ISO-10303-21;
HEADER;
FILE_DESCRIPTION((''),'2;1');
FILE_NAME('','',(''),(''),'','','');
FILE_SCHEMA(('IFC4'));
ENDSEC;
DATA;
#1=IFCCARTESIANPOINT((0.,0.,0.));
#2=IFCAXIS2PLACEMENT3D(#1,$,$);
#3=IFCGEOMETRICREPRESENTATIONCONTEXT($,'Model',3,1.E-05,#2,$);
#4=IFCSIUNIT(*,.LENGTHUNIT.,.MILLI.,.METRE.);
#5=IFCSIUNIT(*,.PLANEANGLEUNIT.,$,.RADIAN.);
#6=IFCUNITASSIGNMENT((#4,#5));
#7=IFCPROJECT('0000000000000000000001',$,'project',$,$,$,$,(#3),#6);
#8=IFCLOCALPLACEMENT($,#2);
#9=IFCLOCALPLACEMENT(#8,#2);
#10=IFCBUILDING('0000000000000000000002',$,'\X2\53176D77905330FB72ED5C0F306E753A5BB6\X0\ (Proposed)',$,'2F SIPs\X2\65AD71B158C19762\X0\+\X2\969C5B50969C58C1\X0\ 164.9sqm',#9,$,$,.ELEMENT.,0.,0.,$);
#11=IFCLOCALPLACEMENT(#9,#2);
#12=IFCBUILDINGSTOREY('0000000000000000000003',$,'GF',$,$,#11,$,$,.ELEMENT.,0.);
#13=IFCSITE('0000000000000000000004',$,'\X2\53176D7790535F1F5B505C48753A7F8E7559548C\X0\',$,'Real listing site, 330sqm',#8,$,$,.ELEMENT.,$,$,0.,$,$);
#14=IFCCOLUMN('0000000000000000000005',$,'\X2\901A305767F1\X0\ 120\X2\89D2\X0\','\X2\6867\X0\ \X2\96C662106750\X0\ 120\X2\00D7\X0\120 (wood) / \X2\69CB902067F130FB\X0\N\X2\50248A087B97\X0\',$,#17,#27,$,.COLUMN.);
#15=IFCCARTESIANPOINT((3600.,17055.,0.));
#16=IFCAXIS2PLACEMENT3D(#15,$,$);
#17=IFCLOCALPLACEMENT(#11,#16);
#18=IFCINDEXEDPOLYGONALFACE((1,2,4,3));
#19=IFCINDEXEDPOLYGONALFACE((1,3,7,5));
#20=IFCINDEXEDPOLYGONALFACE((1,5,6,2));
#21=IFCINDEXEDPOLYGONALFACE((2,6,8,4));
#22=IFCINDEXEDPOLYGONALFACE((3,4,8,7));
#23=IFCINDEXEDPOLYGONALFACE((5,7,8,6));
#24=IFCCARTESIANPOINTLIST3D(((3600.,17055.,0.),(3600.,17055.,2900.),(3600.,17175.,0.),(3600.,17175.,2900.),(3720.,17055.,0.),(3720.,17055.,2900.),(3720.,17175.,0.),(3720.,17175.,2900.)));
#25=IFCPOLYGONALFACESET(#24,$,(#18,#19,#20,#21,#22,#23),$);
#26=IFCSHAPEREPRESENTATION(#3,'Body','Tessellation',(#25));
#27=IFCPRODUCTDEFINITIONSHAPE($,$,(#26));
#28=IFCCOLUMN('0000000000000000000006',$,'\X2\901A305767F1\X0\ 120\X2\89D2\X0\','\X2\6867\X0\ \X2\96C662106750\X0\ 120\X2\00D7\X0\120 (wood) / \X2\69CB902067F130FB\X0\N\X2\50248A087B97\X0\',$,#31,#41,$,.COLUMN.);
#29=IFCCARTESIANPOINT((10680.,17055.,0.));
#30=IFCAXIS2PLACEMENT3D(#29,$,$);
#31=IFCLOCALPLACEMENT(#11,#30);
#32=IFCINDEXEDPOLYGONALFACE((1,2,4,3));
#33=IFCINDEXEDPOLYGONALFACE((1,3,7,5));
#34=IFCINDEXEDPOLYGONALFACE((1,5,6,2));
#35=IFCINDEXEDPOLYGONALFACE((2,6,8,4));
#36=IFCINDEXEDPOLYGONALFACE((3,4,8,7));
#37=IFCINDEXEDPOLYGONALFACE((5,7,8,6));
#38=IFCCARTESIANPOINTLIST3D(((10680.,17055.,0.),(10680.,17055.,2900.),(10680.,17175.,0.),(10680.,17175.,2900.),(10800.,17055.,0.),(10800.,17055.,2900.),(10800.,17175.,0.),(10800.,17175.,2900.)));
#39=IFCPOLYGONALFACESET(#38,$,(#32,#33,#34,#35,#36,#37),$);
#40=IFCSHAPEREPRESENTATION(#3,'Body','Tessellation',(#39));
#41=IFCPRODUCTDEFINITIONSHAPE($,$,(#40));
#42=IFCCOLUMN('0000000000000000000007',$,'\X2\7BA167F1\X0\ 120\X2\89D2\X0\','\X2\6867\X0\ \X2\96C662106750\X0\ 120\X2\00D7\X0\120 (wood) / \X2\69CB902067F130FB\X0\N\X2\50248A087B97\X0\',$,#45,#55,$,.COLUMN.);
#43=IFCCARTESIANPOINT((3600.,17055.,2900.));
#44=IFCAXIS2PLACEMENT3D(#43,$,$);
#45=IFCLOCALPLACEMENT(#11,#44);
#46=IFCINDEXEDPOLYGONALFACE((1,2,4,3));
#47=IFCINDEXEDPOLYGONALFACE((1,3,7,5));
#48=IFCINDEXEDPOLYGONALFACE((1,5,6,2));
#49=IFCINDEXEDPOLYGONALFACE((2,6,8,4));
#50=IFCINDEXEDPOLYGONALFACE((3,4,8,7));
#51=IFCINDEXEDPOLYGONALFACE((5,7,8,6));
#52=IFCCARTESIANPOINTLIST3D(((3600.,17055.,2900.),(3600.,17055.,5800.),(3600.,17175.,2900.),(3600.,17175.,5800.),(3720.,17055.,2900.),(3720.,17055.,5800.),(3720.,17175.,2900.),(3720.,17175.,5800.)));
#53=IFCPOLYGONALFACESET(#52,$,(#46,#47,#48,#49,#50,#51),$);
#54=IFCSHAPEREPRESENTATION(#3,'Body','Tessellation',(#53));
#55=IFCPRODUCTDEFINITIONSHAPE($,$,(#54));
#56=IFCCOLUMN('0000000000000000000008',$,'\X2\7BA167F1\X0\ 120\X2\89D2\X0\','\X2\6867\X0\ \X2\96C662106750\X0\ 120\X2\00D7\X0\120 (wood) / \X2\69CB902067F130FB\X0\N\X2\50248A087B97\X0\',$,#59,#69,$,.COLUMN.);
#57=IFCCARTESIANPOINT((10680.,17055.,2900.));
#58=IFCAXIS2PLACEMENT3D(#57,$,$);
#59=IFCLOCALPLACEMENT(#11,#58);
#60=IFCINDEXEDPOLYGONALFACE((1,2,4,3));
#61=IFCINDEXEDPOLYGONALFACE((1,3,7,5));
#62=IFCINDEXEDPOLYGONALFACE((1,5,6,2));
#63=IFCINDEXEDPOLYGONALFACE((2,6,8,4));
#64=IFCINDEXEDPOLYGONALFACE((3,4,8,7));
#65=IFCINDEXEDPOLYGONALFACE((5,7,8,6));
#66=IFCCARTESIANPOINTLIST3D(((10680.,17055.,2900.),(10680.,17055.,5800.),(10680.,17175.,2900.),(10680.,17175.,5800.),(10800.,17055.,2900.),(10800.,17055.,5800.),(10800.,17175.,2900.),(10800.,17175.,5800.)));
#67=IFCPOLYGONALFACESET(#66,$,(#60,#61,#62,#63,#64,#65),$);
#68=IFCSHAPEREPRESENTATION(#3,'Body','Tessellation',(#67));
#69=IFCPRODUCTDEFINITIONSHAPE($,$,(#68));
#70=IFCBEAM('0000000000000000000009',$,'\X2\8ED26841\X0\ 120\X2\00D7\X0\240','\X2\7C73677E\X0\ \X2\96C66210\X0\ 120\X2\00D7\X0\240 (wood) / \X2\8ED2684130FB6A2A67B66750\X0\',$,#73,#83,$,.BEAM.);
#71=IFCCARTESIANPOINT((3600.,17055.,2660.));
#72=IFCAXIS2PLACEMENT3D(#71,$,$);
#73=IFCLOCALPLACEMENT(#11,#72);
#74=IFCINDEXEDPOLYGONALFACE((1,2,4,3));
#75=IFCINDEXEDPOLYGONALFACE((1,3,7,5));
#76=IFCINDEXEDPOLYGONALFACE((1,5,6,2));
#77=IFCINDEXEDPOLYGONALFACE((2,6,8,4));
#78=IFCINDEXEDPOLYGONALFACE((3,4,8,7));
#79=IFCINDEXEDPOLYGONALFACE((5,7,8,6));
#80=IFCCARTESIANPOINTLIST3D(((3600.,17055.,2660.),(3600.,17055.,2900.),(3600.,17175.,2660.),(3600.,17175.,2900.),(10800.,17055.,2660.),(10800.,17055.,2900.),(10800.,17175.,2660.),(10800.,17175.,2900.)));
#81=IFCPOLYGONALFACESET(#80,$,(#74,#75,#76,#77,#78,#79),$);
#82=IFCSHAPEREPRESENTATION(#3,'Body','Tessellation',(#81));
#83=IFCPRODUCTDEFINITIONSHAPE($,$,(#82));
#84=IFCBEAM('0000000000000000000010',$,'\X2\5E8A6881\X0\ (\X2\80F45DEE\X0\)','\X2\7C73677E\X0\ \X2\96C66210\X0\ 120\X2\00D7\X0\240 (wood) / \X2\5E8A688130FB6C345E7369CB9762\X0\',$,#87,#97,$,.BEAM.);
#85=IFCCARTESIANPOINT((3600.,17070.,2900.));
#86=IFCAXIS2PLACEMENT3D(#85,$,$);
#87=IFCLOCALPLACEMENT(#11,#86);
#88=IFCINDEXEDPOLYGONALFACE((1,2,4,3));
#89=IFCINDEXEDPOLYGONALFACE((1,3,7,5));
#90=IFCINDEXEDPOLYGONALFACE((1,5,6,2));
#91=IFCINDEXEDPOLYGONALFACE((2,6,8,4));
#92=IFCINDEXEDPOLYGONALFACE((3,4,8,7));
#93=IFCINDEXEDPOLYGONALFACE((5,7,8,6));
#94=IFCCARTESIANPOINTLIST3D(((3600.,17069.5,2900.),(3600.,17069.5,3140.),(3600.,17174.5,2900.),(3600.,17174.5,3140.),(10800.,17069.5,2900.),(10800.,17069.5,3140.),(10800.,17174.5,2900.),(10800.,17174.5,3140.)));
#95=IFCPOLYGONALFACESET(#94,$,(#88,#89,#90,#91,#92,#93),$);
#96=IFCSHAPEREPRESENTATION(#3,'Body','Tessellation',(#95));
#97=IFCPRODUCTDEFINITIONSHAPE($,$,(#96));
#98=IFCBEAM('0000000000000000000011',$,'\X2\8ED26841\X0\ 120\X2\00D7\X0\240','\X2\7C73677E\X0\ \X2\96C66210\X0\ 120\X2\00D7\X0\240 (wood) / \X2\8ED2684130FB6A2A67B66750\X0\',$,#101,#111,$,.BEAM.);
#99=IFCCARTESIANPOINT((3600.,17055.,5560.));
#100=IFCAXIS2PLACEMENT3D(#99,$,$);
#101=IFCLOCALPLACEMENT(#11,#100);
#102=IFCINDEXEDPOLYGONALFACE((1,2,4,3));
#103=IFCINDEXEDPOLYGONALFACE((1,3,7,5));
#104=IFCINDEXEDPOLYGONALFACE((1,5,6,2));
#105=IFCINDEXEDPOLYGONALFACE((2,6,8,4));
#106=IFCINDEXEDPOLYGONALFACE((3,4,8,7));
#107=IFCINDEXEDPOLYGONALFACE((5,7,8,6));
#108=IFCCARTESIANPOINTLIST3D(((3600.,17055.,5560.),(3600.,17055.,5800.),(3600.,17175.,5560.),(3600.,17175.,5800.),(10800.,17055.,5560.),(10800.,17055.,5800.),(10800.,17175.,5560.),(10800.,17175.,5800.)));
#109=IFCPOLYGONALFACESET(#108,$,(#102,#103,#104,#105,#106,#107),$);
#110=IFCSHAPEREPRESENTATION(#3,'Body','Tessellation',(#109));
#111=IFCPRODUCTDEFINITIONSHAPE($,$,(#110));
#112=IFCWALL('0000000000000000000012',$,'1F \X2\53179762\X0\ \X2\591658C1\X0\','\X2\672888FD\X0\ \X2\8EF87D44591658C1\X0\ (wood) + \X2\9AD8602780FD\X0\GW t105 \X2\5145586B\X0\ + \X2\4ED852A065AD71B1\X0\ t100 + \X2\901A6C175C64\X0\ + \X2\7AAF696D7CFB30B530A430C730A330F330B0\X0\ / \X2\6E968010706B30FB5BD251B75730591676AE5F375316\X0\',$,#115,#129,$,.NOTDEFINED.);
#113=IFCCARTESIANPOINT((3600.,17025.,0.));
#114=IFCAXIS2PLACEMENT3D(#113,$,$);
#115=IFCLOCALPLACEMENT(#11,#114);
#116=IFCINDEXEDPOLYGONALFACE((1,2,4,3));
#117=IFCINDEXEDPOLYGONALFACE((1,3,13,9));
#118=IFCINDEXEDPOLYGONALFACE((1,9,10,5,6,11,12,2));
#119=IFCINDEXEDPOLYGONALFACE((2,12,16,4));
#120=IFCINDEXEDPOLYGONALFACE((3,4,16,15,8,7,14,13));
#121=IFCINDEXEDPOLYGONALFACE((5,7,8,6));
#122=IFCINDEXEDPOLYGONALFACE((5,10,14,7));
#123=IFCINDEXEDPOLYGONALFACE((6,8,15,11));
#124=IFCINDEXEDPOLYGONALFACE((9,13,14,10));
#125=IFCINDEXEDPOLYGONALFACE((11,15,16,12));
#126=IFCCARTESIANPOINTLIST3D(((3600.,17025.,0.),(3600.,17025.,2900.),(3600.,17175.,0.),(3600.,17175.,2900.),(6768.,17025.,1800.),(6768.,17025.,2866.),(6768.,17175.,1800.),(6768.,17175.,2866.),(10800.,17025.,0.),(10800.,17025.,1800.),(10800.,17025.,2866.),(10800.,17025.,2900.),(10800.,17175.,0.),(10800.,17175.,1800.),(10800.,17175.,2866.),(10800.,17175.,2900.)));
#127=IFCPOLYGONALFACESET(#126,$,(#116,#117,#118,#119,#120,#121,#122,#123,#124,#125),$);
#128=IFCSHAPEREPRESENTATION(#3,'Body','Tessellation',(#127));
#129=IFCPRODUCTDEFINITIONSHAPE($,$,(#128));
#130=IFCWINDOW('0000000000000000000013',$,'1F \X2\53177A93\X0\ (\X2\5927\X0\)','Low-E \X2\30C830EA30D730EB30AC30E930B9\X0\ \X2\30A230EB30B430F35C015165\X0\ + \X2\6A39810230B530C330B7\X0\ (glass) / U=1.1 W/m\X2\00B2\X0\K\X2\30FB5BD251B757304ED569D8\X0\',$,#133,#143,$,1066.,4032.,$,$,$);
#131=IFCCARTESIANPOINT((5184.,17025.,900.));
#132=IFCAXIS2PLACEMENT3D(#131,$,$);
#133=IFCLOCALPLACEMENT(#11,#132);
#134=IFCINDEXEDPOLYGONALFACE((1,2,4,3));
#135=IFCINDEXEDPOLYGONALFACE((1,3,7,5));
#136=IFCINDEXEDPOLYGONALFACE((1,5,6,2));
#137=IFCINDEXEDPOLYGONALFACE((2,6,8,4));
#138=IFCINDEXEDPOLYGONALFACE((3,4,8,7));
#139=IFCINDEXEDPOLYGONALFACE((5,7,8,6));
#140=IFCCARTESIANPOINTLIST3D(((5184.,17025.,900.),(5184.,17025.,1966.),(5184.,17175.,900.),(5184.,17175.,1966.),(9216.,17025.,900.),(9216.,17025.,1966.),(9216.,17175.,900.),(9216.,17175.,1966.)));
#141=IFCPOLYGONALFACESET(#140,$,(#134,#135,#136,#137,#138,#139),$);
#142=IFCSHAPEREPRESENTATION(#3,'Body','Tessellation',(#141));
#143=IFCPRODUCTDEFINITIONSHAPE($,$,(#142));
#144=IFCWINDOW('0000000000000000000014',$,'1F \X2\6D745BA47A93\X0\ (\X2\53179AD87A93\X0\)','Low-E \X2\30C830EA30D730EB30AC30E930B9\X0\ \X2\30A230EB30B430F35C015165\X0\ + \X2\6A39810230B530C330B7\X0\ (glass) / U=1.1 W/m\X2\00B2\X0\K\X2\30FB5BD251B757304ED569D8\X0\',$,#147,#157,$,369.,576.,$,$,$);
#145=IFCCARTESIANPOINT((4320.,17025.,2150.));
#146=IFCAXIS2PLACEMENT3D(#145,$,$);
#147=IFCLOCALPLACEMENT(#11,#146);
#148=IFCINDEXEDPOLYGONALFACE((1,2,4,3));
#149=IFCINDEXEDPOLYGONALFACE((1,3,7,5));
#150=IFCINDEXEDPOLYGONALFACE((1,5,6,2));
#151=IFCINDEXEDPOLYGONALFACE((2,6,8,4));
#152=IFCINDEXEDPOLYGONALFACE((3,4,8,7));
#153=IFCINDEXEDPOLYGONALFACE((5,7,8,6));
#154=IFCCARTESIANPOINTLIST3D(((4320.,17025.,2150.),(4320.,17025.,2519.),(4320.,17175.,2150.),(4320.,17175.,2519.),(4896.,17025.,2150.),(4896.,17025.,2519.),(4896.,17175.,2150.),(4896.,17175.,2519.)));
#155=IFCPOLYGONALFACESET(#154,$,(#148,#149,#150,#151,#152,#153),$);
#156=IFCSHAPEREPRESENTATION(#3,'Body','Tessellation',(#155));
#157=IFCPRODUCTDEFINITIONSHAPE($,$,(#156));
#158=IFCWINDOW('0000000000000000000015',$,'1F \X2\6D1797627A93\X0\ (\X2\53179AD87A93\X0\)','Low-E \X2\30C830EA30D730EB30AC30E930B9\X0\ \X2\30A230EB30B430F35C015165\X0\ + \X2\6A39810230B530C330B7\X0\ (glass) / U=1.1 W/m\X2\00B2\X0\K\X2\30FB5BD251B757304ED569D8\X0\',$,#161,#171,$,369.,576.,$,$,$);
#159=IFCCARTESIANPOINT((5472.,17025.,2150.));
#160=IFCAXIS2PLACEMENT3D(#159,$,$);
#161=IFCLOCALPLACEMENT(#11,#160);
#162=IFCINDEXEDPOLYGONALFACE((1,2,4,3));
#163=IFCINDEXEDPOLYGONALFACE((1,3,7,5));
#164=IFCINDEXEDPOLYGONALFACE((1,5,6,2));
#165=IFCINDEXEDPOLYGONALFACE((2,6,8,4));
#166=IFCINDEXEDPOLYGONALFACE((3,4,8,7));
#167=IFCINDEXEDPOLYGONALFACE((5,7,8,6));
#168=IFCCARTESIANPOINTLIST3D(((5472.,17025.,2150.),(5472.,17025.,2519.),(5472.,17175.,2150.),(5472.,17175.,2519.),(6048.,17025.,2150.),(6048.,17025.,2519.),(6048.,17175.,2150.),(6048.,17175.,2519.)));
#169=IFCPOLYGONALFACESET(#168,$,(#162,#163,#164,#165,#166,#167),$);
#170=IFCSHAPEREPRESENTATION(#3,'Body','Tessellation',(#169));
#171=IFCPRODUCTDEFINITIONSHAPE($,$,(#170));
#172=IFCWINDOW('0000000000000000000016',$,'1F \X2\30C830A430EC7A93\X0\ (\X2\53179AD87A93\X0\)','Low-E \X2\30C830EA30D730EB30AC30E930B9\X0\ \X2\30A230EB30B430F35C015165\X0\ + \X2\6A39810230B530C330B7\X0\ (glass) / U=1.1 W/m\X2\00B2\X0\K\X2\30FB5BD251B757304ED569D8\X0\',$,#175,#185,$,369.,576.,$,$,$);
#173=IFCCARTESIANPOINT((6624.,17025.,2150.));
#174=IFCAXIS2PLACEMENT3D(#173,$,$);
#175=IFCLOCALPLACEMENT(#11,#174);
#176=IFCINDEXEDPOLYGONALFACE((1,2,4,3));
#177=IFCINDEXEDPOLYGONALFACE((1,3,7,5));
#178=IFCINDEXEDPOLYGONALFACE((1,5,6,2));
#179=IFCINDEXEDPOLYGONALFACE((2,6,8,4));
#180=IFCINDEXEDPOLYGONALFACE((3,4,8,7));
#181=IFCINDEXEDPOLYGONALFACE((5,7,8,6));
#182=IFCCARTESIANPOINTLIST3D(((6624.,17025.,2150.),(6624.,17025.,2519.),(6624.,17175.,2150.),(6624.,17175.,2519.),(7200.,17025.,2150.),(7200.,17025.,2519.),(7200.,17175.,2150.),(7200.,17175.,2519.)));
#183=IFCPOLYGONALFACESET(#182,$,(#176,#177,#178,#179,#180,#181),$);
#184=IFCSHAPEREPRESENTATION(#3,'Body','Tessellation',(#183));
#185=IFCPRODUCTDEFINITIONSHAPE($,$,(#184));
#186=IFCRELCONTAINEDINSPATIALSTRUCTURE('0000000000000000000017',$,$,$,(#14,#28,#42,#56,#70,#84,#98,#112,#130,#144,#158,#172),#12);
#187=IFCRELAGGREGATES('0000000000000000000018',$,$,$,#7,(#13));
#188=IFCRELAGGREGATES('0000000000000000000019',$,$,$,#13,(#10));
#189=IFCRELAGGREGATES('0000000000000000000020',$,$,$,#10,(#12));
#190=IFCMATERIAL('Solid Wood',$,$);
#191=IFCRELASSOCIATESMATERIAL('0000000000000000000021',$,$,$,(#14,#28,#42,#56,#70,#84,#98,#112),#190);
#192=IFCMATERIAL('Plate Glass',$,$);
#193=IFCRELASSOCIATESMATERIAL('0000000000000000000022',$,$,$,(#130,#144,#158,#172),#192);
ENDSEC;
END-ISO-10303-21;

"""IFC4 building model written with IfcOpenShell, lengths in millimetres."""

from ifc_helpers import new_model, si_unit, frame, frame_2d, origin, place, context, project, spatial, rectangle, extrude, material, element, fill, save


model = new_model("IFC4")

# Units and contexts
model_context = context("Model", 3, precision=1e-05, world=origin())
ifc_project = project(units=[si_unit("LENGTHUNIT", "METRE", prefix="MILLI"), si_unit("PLANEANGLEUNIT", "RADIAN")], contexts=[model_context])

# Site, building, storey
site_placement = place(None, origin())
site = spatial("IfcSite", under=ifc_project, at=site_placement, Name="北海道弟子屈町美留和", ObjectType="Real listing site, 330sqm", CompositionType="ELEMENT", RefElevation=0.0)
building_placement = place(site_placement, origin())
building = spatial("IfcBuilding", under=site, at=building_placement, Name="北海道・狭小の町家 (Proposed)", ObjectType="2F SIPs断熱壁面+障子障壁 164.9sqm", CompositionType="ELEMENT", ElevationOfRefHeight=0.0, ElevationOfTerrain=0.0)
storey_placement = place(building_placement, origin())
storey = spatial("IfcBuildingStorey", under=building, at=storey_placement, Name="GF", CompositionType="ELEMENT", Elevation=0.0)

# Columns
ifc_material_1 = material(Name="Solid Wood")
column_1_placement = place(storey_placement, frame((3600.0, 17055.0, 0.0)))
element("IfcColumn", 1, at=column_1_placement, inside=storey, material=ifc_material_1, Name="通し柱 120角", Description="桧 集成材 120×120 (wood) / 構造柱・N値計算", PredefinedType="COLUMN", context=model_context, shape_type="SweptSolid", body=[
    extrude(rectangle(XDim=120.0, YDim=120.0, at=frame_2d((60.0, 60.0))), frame((3600.0, 17055.0, 0.0)), (0.0, 0.0, 1.0), 2900.0),
])
column_2_placement = place(storey_placement, frame((10680.0, 17055.0, 0.0)))
element("IfcColumn", 2, at=column_2_placement, inside=storey, material=ifc_material_1, Name="通し柱 120角", Description="桧 集成材 120×120 (wood) / 構造柱・N値計算", PredefinedType="COLUMN", context=model_context, shape_type="SweptSolid", body=[
    extrude(rectangle(XDim=120.0, YDim=120.0, at=frame_2d((60.0, 60.0))), frame((10680.0, 17055.0, 0.0)), (0.0, 0.0, 1.0), 2900.0),
])
column_3_placement = place(storey_placement, frame((3600.0, 17055.0, 2900.0)))
element("IfcColumn", 3, at=column_3_placement, inside=storey, material=ifc_material_1, Name="管柱 120角", Description="桧 集成材 120×120 (wood) / 構造柱・N値計算", PredefinedType="COLUMN", context=model_context, shape_type="SweptSolid", body=[
    extrude(rectangle(XDim=120.0, YDim=120.0, at=frame_2d((60.0, 60.0))), frame((3600.0, 17055.0, 2900.0)), (0.0, 0.0, 1.0), 2900.0),
])
column_4_placement = place(storey_placement, frame((10680.0, 17055.0, 2900.0)))
element("IfcColumn", 4, at=column_4_placement, inside=storey, material=ifc_material_1, Name="管柱 120角", Description="桧 集成材 120×120 (wood) / 構造柱・N値計算", PredefinedType="COLUMN", context=model_context, shape_type="SweptSolid", body=[
    extrude(rectangle(XDim=120.0, YDim=120.0, at=frame_2d((60.0, 60.0))), frame((10680.0, 17055.0, 2900.0)), (0.0, 0.0, 1.0), 2900.0),
])

# Beams
beam_1_placement = place(storey_placement, frame((3600.0, 17055.0, 2660.0)))
element("IfcBeam", 5, at=beam_1_placement, inside=storey, material=ifc_material_1, Name="軒桁 120×240", Description="米松 集成 120×240 (wood) / 軒桁・横架材", PredefinedType="BEAM", context=model_context, shape_type="SweptSolid", body=[
    extrude(rectangle(XDim=7200.0, YDim=120.0, at=frame_2d((3600.0, 60.0))), frame((3600.0, 17055.0, 2660.0)), (0.0, 0.0, 1.0), 240.0),
])
beam_2_placement = place(storey_placement, frame((3600.0, 17070.0, 2900.0)))
element("IfcBeam", 6, at=beam_2_placement, inside=storey, material=ifc_material_1, Name="床梁 (胴差)", Description="米松 集成 120×240 (wood) / 床梁・水平構面", PredefinedType="BEAM", context=model_context, shape_type="SweptSolid", body=[
    extrude(rectangle(XDim=7200.0, YDim=105.0, at=frame_2d((3600.0, 52.0))), frame((3600.0, 17070.0, 2900.0)), (0.0, 0.0, 1.0), 240.0),
])
beam_3_placement = place(storey_placement, frame((3600.0, 17055.0, 5560.0)))
element("IfcBeam", 7, at=beam_3_placement, inside=storey, material=ifc_material_1, Name="軒桁 120×240", Description="米松 集成 120×240 (wood) / 軒桁・横架材", PredefinedType="BEAM", context=model_context, shape_type="SweptSolid", body=[
    extrude(rectangle(XDim=7200.0, YDim=120.0, at=frame_2d((3600.0, 60.0))), frame((3600.0, 17055.0, 5560.0)), (0.0, 0.0, 1.0), 240.0),
])

# Wall, openings, windows
wall_1_placement = place(storey_placement, frame((3600.0, 17025.0, 0.0)))
wall_1 = element("IfcWall", 8, at=wall_1_placement, inside=storey, material=ifc_material_1, Name="1F 北面 外壁", Description="木製 軸組外壁 (wood) + 高性能GW t105 充填 + 付加断熱 t100 + 通気層 + 窯業系サイディング / 準耐火・寒冷地外皮強化", PredefinedType="NOTDEFINED", context=model_context, shape_type="SweptSolid", body=[
    extrude(rectangle(XDim=7200.0, YDim=150.0, at=frame_2d((3600.0, 75.0))), frame((3600.0, 17025.0, 0.0)), (0.0, 0.0, 1.0), 2900.0),
])
opening_1_placement = place(storey_placement, frame((5184.0, 17025.0, 900.0)))
opening_1 = element("IfcOpeningElement", 9, at=opening_1_placement, cuts=wall_1, PredefinedType="NOTDEFINED", context=model_context, shape_type="SweptSolid", body=[
    extrude(rectangle(XDim=4032.0, YDim=150.0, at=frame_2d((2016.0, 75.0))), frame((5184.0, 17025.0, 900.0)), (0.0, 0.0, 1.0), 1066.0),
])
opening_2_placement = place(storey_placement, frame((4320.0, 17025.0, 2150.0)))
opening_2 = element("IfcOpeningElement", 10, at=opening_2_placement, cuts=wall_1, PredefinedType="NOTDEFINED", context=model_context, shape_type="SweptSolid", body=[
    extrude(rectangle(XDim=576.0, YDim=150.0, at=frame_2d((288.0, 75.0))), frame((4320.0, 17025.0, 2150.0)), (0.0, 0.0, 1.0), 369.0),
])
opening_3_placement = place(storey_placement, frame((5472.0, 17025.0, 2150.0)))
opening_3 = element("IfcOpeningElement", 11, at=opening_3_placement, cuts=wall_1, PredefinedType="NOTDEFINED", context=model_context, shape_type="SweptSolid", body=[
    extrude(rectangle(XDim=576.0, YDim=150.0, at=frame_2d((288.0, 75.0))), frame((5472.0, 17025.0, 2150.0)), (0.0, 0.0, 1.0), 369.0),
])
opening_4_placement = place(storey_placement, frame((6624.0, 17025.0, 2150.0)))
opening_4 = element("IfcOpeningElement", 12, at=opening_4_placement, cuts=wall_1, PredefinedType="NOTDEFINED", context=model_context, shape_type="SweptSolid", body=[
    extrude(rectangle(XDim=576.0, YDim=150.0, at=frame_2d((288.0, 75.0))), frame((6624.0, 17025.0, 2150.0)), (0.0, 0.0, 1.0), 369.0),
])
ifc_material_2 = material(Name="Plate Glass")
window_1_placement = place(storey_placement, frame((5184.0, 17025.0, 900.0)))
window_1 = element("IfcWindow", 13, at=window_1_placement, inside=storey, material=ifc_material_2, Name="1F 北窓 (大)", Description="Low-E トリプルガラス アルゴン封入 + 樹脂サッシ (glass) / U=1.1 W/m²K・寒冷地仕様", OverallHeight=1066.0, OverallWidth=4032.0, context=model_context, shape_type="SweptSolid", body=[
    extrude(rectangle(XDim=4032.0, YDim=150.0, at=frame_2d((2016.0, 75.0))), frame((5184.0, 17025.0, 900.0)), (0.0, 0.0, 1.0), 1066.0),
])
fill(opening_1, window_1)
window_2_placement = place(storey_placement, frame((4320.0, 17025.0, 2150.0)))
window_2 = element("IfcWindow", 14, at=window_2_placement, inside=storey, material=ifc_material_2, Name="1F 浴室窓 (北高窓)", Description="Low-E トリプルガラス アルゴン封入 + 樹脂サッシ (glass) / U=1.1 W/m²K・寒冷地仕様", OverallHeight=369.0, OverallWidth=576.0, context=model_context, shape_type="SweptSolid", body=[
    extrude(rectangle(XDim=576.0, YDim=150.0, at=frame_2d((288.0, 75.0))), frame((4320.0, 17025.0, 2150.0)), (0.0, 0.0, 1.0), 369.0),
])
fill(opening_2, window_2)
window_3_placement = place(storey_placement, frame((5472.0, 17025.0, 2150.0)))
window_3 = element("IfcWindow", 15, at=window_3_placement, inside=storey, material=ifc_material_2, Name="1F 洗面窓 (北高窓)", Description="Low-E トリプルガラス アルゴン封入 + 樹脂サッシ (glass) / U=1.1 W/m²K・寒冷地仕様", OverallHeight=369.0, OverallWidth=576.0, context=model_context, shape_type="SweptSolid", body=[
    extrude(rectangle(XDim=576.0, YDim=150.0, at=frame_2d((288.0, 75.0))), frame((5472.0, 17025.0, 2150.0)), (0.0, 0.0, 1.0), 369.0),
])
fill(opening_3, window_3)
window_4_placement = place(storey_placement, frame((6624.0, 17025.0, 2150.0)))
window_4 = element("IfcWindow", 16, at=window_4_placement, inside=storey, material=ifc_material_2, Name="1F トイレ窓 (北高窓)", Description="Low-E トリプルガラス アルゴン封入 + 樹脂サッシ (glass) / U=1.1 W/m²K・寒冷地仕様", OverallHeight=369.0, OverallWidth=576.0, context=model_context, shape_type="SweptSolid", body=[
    extrude(rectangle(XDim=576.0, YDim=150.0, at=frame_2d((288.0, 75.0))), frame((6624.0, 17025.0, 2150.0)), (0.0, 0.0, 1.0), 369.0),
])
fill(opening_4, window_4)

save(model, "model.ifc")
